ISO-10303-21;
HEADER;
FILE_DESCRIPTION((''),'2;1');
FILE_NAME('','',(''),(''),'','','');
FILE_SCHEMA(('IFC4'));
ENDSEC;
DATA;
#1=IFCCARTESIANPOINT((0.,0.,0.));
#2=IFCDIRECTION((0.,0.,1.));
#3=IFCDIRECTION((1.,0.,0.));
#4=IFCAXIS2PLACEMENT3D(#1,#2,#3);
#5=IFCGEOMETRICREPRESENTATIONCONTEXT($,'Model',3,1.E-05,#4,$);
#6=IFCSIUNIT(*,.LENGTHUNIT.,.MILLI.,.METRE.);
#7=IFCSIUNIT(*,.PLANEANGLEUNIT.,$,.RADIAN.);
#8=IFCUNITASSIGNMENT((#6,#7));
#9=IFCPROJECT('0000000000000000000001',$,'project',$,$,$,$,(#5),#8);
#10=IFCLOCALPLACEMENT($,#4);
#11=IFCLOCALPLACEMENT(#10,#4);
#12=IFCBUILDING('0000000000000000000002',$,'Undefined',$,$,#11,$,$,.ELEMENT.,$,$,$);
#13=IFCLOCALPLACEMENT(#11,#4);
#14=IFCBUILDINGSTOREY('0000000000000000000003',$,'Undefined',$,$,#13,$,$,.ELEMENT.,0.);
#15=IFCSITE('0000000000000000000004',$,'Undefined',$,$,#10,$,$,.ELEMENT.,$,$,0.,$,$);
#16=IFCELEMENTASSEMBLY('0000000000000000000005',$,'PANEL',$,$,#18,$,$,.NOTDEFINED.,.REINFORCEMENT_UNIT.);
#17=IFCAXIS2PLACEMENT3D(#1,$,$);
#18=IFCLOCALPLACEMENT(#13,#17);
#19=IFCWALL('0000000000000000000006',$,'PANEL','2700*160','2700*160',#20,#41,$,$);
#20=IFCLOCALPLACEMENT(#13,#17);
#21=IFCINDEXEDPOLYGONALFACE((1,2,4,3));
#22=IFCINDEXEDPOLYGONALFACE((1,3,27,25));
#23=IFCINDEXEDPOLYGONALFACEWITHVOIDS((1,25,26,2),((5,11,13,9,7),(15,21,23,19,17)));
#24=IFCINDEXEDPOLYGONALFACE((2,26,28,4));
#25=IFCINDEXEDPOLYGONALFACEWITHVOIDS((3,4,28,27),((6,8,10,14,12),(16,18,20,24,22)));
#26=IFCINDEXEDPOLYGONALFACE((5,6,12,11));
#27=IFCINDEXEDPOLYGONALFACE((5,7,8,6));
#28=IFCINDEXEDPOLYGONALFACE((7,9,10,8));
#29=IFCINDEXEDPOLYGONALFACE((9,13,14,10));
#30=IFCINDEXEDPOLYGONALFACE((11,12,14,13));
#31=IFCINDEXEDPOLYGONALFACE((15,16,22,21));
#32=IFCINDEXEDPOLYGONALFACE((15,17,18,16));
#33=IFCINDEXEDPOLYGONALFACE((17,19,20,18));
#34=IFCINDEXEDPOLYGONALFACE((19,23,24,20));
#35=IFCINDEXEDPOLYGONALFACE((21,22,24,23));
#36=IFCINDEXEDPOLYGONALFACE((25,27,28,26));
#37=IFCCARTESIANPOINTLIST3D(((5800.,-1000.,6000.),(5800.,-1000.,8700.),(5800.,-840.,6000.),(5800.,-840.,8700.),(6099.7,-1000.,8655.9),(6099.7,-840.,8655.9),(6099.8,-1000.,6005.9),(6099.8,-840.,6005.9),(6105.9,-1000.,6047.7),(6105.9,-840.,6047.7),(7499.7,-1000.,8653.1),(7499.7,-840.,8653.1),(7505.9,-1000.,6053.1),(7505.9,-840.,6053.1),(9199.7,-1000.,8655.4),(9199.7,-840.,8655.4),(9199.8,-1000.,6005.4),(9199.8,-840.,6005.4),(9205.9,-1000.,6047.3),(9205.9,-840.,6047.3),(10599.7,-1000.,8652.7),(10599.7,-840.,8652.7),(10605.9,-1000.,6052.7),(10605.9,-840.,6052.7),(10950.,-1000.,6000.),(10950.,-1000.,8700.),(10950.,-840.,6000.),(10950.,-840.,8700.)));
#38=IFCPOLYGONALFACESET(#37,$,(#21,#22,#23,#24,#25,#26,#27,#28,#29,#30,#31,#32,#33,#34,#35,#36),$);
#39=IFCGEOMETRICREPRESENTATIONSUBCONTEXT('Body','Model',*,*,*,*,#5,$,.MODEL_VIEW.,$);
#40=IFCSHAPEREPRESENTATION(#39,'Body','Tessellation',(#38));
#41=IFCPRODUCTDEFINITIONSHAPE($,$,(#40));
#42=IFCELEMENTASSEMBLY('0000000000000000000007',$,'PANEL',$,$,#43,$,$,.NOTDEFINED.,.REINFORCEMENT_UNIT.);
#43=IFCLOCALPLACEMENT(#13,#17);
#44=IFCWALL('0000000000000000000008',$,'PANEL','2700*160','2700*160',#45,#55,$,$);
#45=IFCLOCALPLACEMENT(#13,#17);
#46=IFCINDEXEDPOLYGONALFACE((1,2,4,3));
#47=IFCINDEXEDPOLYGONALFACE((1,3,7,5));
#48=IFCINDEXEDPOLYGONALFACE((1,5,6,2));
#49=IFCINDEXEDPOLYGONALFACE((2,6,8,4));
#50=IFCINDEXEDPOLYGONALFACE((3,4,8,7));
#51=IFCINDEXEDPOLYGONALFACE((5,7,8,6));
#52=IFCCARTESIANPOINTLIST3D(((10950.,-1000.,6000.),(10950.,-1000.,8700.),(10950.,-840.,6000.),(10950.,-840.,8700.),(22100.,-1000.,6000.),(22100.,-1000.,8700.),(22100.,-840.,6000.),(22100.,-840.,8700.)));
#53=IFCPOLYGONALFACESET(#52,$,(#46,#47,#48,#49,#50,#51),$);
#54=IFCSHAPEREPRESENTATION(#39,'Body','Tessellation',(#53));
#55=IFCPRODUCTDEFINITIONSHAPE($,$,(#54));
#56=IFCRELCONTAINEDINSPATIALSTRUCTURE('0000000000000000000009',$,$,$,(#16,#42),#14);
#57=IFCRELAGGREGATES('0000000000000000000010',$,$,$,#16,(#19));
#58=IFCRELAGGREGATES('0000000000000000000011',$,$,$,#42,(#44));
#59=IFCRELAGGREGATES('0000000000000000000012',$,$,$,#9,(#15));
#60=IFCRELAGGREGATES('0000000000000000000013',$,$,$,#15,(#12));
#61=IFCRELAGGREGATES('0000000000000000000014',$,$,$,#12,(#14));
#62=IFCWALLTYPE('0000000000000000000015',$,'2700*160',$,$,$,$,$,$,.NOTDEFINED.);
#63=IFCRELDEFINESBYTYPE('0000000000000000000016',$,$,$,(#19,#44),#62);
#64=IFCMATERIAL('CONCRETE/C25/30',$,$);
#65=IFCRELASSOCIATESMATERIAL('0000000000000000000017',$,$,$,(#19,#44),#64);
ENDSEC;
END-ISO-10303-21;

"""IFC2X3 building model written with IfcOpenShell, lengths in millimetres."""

from ifc_helpers import new_model, si_unit, frame, frame_2d, origin_with_axes, place, context, subcontext, project, spatial, polyline, rectangle, outline, extrude, boolean, material, type_object, element, aggregate, save


model = new_model("IFC2X3")

# Units and contexts
model_context = context("Model", 3, precision=1e-05, world=origin_with_axes())
body_context = subcontext(model_context, "Body", "Model", "MODEL_VIEW")
ifc_project = project(units=[si_unit("LENGTHUNIT", "METRE", prefix="MILLI"), si_unit("PLANEANGLEUNIT", "RADIAN")], contexts=[model_context])

# Site, building, storey
site_placement = place(None, origin_with_axes())
site = spatial("IfcSite", under=ifc_project, at=site_placement, Name="Undefined", CompositionType="ELEMENT", RefElevation=0.0)
building_placement = place(site_placement, origin_with_axes())
building = spatial("IfcBuilding", under=site, at=building_placement, Name="Undefined", CompositionType="ELEMENT")
storey_placement = place(building_placement, origin_with_axes())
storey = spatial("IfcBuildingStorey", under=building, at=storey_placement, Name="Undefined", CompositionType="ELEMENT", Elevation=0.0)

# Shared definitions
ifc_material = material(Name="CONCRETE/C25/30")

# Element assemblies, walls
wall_type = type_object("IfcWallType", Name="2700*160", PredefinedType="NOTDEFINED")
assembly_1_placement = place(storey_placement, origin_with_axes())
assembly_1 = element("IfcElementAssembly", 1, at=assembly_1_placement, inside=storey, Name="PANEL", AssemblyPlace="NOTDEFINED", PredefinedType="REINFORCEMENT_UNIT")
wall_1_placement = place(assembly_1_placement, frame((5800.0, -920.0, 6000.0), z_axis=(0.0, 0.0, 1.0), x_axis=(1.0, 0.0, 0.0)))
wall_1 = element("IfcWall", 2, at=wall_1_placement, type_object=wall_type, material=ifc_material, Name="PANEL", Description="2700*160", ObjectType="2700*160", context=body_context, shape_type="CSG", body=[
    boolean("DIFFERENCE", boolean("DIFFERENCE", extrude(rectangle(XDim=5150.0, YDim=160.0, at=frame_2d((0.0, 2575.0), x_axis=(0.0, -1.0))), frame((0.0, 0.0, 0.0), z_axis=(0.0, 0.0, 1.0), x_axis=(0.0, -1.0, 0.0)), (0.0, 0.0, 1.0), 2700.0), extrude(outline(polyline([(0.0, 0.0), (2650.0, 0.0), (2647.2, 1400.0), (47.2, 1406.1), (41.9, 6.1), (0.0, 0.0), (0.0, 0.0)])), frame((299.8, -82.5, 5.9), z_axis=(0.0, 1.0, 0.0), x_axis=(-0.00004, 0.0, 1.0)), (0.0, 0.0, 1.0), 165.0)), extrude(outline(polyline([(0.0, 0.0), (2650.0, 0.0), (2647.2, 1400.0), (47.2, 1406.1), (41.9, 6.1), (0.0, 0.0), (0.0, 0.0)])), frame((3399.8, -82.5, 5.4), z_axis=(0.0, 1.0, 0.0), x_axis=(-0.00004, 0.0, 1.0)), (0.0, 0.0, 1.0), 165.0)),
])
aggregate(assembly_1, [wall_1])
assembly_2_placement = place(storey_placement, origin_with_axes())
assembly_2 = element("IfcElementAssembly", 3, at=assembly_2_placement, inside=storey, Name="PANEL", AssemblyPlace="NOTDEFINED", PredefinedType="REINFORCEMENT_UNIT")
wall_2_placement = place(assembly_2_placement, frame((10950.0, -920.0, 6000.0), z_axis=(0.0, 0.0, 1.0), x_axis=(1.0, 0.0, 0.0)))
wall_2 = element("IfcWall", 4, at=wall_2_placement, type_object=wall_type, material=ifc_material, Name="PANEL", Description="2700*160", ObjectType="2700*160", context=body_context, shape_type="SweptSolid", body=[
    extrude(rectangle(XDim=11150.0, YDim=160.0, at=frame_2d((0.0, 5575.0), x_axis=(0.0, -1.0))), frame((0.0, 0.0, 0.0), z_axis=(0.0, 0.0, 1.0), x_axis=(0.0, -1.0, 0.0)), (0.0, 0.0, 1.0), 2700.0),
])
aggregate(assembly_2, [wall_2])

save(model, "model.ifc")
